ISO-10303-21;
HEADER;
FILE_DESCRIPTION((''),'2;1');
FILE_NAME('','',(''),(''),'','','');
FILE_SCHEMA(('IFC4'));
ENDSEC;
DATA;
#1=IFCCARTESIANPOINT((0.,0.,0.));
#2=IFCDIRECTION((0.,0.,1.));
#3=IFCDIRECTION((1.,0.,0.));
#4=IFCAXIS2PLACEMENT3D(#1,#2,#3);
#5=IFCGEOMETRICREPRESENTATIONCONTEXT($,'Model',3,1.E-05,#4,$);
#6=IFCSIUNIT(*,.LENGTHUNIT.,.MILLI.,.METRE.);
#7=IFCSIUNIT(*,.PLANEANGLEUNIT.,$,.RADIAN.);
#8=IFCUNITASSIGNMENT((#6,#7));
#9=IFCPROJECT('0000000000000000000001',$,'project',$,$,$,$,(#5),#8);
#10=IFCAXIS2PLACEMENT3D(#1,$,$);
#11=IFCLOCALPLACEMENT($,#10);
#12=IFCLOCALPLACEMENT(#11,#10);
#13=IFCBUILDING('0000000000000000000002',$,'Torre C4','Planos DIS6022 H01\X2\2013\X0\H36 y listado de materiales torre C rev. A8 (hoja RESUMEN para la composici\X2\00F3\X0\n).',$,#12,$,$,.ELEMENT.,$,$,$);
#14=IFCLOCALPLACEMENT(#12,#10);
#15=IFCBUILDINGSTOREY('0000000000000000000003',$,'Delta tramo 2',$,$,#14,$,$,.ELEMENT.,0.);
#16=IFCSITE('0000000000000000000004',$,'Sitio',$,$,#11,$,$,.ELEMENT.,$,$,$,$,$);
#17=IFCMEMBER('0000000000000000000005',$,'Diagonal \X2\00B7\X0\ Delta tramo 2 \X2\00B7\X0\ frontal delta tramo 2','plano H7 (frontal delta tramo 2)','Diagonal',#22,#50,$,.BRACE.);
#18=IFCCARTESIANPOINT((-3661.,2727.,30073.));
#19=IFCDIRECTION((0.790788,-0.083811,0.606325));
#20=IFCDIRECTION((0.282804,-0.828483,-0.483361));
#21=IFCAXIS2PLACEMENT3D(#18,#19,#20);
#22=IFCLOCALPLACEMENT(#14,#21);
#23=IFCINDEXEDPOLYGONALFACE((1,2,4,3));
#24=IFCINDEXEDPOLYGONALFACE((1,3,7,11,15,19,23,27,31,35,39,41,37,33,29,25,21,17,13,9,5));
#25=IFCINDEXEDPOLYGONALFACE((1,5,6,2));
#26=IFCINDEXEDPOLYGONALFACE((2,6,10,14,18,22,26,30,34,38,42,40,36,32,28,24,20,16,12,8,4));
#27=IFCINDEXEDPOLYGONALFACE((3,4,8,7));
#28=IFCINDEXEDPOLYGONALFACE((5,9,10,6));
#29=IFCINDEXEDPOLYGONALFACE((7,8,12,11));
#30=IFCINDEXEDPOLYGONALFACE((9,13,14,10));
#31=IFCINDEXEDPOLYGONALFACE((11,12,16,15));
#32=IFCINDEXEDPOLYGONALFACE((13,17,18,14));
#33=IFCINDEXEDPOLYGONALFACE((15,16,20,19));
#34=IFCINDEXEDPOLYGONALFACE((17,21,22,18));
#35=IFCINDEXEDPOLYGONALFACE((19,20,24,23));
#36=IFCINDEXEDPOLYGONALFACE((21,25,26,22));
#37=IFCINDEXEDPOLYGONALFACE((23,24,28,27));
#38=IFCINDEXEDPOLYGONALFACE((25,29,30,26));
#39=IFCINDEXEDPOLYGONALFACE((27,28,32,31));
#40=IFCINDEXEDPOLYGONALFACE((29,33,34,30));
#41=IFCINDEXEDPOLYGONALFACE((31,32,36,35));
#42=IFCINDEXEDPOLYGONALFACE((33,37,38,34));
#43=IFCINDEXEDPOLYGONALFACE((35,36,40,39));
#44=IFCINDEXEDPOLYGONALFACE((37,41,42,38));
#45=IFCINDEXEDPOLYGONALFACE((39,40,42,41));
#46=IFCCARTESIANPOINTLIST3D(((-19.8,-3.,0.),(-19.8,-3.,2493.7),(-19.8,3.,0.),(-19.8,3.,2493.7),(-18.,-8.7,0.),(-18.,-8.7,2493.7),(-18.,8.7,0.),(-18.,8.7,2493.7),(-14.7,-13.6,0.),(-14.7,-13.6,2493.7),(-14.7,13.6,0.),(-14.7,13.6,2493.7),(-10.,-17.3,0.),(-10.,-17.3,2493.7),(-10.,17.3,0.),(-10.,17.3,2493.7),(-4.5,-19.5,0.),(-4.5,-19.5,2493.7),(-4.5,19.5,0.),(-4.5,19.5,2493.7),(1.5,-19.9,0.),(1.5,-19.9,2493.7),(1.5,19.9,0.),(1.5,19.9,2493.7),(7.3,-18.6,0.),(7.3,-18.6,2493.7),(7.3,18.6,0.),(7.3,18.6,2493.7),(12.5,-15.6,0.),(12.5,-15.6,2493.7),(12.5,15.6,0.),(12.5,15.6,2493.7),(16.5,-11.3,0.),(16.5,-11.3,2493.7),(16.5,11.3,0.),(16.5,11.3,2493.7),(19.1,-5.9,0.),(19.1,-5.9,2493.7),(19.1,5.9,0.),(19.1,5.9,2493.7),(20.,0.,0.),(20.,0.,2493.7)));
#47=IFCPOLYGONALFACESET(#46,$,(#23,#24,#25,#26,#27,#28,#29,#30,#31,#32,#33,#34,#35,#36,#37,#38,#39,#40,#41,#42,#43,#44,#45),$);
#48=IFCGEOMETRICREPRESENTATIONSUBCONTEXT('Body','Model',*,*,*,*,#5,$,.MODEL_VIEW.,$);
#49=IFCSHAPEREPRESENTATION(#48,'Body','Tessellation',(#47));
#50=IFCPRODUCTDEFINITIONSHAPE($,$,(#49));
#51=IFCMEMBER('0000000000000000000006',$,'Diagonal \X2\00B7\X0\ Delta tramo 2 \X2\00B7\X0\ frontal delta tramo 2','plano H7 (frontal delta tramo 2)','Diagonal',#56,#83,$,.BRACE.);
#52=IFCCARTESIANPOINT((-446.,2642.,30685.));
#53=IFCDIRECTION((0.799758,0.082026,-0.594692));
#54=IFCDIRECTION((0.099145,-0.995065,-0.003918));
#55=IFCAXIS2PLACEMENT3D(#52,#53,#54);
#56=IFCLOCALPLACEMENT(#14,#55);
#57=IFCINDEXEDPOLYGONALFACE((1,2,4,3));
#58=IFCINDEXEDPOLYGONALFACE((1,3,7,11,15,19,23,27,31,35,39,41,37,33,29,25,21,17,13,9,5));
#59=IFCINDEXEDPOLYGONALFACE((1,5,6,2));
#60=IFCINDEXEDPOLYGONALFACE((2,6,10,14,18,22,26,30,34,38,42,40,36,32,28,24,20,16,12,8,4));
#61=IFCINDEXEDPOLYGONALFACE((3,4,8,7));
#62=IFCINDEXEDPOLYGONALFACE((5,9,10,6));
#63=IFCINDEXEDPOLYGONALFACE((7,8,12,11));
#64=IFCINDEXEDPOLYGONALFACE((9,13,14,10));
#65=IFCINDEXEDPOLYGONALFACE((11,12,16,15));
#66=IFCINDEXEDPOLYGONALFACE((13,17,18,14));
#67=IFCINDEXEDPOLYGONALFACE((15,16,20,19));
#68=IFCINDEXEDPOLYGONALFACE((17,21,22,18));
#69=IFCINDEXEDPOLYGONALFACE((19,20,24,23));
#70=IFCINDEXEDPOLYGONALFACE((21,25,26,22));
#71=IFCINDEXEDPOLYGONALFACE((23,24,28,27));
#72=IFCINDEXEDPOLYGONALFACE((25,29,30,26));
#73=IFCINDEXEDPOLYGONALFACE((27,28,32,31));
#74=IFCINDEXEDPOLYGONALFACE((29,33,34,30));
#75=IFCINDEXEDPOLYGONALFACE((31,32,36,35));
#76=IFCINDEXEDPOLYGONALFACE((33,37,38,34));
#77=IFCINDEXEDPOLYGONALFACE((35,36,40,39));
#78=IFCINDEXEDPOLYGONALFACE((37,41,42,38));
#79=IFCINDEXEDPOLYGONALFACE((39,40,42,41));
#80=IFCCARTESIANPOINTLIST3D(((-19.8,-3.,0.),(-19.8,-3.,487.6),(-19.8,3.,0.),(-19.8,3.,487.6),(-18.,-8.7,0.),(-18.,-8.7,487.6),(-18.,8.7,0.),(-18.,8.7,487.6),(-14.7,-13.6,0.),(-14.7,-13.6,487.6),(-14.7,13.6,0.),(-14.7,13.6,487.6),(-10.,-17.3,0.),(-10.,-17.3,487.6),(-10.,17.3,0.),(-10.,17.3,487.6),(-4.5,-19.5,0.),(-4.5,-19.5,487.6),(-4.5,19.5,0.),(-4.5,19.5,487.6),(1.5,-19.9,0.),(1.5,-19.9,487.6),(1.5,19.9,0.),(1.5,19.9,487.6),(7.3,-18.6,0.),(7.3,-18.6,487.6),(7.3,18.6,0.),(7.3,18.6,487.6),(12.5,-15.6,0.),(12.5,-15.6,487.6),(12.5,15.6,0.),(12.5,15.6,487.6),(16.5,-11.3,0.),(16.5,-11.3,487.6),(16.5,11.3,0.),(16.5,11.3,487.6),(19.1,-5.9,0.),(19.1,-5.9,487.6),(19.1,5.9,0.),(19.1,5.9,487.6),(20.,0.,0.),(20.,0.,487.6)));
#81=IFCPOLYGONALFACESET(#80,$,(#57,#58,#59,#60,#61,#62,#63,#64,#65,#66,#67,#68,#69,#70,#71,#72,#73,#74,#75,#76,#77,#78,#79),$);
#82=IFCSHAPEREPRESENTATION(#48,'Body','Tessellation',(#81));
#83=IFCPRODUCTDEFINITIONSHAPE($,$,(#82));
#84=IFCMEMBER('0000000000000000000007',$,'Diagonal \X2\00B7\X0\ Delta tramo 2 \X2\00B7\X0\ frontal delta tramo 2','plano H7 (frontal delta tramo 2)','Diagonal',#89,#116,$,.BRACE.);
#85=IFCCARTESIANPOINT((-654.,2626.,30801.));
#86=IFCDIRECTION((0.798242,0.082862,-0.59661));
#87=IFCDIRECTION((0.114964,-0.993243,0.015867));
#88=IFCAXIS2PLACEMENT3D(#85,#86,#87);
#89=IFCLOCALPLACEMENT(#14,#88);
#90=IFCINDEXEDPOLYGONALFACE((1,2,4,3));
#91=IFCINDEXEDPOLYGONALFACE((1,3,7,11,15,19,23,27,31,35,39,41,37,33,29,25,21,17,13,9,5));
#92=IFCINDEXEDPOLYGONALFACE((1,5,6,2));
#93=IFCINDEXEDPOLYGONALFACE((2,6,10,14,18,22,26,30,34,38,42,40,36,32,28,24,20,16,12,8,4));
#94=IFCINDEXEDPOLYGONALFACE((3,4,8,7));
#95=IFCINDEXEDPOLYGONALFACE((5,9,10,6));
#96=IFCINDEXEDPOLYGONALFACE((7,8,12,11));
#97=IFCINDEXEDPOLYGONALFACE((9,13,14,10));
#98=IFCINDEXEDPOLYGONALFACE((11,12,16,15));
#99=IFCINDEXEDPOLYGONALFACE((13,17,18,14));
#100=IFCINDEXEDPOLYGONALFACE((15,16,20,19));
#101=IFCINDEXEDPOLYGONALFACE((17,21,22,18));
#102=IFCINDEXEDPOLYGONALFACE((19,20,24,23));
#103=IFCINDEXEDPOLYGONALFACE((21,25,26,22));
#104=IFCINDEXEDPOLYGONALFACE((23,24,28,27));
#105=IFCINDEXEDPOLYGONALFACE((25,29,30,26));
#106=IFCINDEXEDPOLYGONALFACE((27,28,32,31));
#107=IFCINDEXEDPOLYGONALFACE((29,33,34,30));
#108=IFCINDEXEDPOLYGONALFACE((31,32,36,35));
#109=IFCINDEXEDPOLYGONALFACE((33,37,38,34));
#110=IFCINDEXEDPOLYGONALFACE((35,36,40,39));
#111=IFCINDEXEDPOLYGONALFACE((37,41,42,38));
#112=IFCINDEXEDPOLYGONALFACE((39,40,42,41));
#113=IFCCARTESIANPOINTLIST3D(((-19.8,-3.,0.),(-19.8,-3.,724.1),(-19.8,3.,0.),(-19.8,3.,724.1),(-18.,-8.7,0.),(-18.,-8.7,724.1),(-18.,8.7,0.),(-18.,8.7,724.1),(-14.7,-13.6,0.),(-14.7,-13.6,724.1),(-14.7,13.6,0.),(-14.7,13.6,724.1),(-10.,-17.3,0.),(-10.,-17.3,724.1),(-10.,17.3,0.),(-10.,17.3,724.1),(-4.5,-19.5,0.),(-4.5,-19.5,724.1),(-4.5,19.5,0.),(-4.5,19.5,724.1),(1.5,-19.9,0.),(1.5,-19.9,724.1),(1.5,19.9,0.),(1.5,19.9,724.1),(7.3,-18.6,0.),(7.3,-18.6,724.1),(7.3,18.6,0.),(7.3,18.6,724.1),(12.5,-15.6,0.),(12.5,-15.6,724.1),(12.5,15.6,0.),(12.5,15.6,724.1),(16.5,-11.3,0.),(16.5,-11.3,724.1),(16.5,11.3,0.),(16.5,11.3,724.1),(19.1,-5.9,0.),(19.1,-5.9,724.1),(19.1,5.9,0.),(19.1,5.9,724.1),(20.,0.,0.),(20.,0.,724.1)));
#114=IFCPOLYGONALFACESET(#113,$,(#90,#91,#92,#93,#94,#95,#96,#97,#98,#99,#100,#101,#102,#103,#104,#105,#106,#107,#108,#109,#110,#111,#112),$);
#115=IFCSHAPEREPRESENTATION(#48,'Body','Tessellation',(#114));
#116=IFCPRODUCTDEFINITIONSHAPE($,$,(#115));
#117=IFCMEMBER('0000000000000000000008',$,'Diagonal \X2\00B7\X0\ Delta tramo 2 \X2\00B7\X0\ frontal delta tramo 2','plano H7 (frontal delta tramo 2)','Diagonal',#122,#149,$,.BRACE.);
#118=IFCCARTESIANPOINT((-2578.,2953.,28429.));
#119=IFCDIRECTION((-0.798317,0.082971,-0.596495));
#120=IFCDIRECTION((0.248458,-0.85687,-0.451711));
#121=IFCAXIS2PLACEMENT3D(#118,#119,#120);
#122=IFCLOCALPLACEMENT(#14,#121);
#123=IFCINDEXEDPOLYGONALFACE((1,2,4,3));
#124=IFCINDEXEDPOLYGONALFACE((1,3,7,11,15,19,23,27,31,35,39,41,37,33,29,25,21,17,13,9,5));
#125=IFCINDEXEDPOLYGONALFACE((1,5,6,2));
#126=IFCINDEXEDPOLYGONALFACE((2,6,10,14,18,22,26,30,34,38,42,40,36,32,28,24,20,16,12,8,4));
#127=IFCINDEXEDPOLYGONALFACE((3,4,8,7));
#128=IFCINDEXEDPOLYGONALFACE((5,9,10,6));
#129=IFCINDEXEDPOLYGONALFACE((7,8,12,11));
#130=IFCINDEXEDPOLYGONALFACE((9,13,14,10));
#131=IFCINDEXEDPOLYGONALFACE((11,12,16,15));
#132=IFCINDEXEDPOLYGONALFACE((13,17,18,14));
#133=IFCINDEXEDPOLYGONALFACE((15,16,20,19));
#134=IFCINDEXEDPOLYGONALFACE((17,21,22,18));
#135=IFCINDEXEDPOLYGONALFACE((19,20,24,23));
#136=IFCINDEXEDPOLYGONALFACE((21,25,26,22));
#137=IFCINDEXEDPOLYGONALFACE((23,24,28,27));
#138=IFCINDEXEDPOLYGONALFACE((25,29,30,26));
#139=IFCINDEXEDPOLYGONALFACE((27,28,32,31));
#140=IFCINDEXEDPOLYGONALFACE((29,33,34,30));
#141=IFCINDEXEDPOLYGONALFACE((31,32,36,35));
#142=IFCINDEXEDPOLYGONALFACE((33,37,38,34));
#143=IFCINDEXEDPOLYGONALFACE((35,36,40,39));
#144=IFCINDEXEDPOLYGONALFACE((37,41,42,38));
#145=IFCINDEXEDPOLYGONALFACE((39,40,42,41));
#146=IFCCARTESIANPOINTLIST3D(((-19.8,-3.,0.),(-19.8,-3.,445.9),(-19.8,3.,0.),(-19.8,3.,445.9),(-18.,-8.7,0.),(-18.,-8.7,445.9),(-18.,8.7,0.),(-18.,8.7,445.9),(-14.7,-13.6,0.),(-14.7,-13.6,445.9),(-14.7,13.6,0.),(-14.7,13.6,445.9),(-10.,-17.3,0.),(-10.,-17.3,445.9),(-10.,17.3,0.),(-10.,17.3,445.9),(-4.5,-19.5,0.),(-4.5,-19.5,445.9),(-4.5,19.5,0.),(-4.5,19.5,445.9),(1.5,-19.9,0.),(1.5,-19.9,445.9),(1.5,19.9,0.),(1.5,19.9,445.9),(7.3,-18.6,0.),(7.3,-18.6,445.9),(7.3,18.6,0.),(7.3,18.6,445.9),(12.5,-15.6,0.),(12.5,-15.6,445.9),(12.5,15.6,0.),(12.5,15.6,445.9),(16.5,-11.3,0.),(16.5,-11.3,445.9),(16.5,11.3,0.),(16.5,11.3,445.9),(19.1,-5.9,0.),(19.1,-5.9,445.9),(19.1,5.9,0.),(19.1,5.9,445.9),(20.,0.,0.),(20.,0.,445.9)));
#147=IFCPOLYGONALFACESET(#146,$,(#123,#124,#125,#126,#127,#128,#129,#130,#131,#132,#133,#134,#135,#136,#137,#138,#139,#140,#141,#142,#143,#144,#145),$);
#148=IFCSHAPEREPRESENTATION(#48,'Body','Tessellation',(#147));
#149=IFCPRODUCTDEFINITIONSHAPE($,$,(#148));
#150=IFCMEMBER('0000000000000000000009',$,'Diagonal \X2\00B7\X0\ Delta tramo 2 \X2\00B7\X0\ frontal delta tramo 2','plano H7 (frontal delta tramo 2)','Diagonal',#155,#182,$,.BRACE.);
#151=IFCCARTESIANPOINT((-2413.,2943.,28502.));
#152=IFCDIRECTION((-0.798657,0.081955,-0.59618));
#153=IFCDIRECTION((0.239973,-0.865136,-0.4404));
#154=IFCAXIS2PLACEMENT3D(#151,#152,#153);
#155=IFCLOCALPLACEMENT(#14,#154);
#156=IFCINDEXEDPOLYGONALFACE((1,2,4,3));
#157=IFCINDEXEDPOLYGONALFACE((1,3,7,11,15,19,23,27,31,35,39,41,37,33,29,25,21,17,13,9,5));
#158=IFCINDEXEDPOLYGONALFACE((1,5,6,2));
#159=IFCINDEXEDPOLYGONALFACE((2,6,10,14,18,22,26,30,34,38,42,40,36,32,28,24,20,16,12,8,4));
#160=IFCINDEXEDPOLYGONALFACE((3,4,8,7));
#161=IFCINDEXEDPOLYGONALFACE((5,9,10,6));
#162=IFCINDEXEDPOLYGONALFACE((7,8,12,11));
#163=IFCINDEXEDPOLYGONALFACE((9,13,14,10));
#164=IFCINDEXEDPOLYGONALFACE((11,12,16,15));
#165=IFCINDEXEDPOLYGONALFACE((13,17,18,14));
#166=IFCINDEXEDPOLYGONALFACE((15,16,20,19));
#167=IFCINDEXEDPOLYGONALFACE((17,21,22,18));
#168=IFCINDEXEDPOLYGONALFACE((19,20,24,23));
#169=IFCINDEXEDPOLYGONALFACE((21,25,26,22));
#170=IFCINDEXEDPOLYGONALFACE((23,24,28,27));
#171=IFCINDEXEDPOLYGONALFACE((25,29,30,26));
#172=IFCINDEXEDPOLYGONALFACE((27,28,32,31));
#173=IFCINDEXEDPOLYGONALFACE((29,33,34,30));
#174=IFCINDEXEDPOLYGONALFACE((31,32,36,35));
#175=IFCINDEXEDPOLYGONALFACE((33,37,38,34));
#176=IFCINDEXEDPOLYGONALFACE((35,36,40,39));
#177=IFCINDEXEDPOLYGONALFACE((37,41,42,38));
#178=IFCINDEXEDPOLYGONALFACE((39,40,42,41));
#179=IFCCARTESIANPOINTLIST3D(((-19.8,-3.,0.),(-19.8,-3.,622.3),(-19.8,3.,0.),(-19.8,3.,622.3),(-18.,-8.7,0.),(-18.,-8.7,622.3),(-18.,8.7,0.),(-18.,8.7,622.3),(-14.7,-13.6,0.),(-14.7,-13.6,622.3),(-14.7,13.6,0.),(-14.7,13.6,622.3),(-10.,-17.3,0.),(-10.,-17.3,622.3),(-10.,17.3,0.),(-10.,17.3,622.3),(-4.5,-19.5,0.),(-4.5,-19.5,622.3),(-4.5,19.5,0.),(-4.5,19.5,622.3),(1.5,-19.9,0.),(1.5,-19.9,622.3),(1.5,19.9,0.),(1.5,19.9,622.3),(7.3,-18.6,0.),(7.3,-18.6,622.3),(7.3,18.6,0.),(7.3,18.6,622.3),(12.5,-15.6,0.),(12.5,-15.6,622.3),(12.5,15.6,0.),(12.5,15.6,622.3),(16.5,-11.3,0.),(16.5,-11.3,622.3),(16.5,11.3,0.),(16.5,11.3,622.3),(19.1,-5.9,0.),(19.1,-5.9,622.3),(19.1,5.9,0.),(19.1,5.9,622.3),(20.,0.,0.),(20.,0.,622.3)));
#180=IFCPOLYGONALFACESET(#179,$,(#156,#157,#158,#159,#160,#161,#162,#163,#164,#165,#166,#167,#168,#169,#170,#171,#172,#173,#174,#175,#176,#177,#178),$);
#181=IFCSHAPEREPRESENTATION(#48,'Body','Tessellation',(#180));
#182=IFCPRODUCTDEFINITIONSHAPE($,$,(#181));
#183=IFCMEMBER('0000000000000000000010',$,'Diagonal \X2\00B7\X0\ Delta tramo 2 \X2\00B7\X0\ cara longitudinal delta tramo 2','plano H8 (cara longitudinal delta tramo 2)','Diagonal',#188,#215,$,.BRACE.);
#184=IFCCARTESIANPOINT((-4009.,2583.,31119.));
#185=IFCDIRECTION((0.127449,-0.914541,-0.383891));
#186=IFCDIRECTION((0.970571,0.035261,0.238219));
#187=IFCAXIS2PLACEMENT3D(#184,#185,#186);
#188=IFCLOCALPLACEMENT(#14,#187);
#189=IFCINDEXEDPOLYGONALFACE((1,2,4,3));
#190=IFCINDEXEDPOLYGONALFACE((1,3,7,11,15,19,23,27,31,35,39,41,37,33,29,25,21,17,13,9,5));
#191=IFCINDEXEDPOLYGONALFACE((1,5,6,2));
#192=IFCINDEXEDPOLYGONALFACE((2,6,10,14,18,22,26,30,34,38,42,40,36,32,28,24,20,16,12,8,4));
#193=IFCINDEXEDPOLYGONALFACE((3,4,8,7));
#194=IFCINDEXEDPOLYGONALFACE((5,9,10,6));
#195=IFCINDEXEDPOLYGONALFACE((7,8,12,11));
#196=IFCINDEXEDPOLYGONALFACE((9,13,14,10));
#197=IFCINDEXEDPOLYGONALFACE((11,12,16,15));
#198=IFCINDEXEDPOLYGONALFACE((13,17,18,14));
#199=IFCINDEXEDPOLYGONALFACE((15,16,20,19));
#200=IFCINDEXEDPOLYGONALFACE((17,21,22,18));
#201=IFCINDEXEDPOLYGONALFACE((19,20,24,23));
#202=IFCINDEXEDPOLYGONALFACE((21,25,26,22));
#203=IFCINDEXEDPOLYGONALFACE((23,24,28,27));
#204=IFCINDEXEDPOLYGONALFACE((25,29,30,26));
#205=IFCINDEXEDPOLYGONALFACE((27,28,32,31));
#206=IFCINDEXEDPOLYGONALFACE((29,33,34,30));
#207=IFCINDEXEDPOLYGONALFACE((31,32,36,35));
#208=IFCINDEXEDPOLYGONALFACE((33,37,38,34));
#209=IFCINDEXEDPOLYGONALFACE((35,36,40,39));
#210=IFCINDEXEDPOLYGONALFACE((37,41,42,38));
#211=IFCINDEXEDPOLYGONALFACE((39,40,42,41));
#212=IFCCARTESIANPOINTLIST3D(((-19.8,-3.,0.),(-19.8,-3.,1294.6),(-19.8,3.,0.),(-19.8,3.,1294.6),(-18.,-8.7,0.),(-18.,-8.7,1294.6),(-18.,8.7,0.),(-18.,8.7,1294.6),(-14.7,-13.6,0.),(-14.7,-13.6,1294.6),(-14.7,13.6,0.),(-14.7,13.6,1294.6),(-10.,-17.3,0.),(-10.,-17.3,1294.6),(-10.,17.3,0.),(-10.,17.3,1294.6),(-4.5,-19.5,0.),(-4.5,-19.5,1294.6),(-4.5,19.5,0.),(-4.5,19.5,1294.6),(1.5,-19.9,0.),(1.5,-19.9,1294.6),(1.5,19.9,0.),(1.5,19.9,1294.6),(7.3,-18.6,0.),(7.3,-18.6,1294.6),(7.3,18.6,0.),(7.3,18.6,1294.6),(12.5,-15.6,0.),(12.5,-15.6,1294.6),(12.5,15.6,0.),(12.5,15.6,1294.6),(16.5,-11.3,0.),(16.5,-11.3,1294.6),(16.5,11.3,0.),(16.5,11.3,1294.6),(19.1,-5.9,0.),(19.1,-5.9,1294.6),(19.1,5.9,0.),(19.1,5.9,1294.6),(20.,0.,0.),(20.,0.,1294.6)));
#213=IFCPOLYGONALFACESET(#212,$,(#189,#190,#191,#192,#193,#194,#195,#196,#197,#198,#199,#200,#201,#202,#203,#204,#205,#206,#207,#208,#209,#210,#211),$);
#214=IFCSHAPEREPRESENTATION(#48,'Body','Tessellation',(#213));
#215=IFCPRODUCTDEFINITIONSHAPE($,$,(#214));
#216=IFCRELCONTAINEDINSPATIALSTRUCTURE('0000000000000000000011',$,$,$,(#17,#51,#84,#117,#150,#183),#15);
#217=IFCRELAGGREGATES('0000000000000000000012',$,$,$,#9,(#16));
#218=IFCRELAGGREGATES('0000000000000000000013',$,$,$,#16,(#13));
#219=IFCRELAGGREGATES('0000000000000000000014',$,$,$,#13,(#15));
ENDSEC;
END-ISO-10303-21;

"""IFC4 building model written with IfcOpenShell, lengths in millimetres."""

from ifc_helpers import new_model, si_unit, frame, origin, origin_with_axes, place, context, subcontext, project, spatial, circle, extrude, element, save


model = new_model("IFC4")

# Units and contexts
model_context = context("Model", 3, precision=1e-05, world=origin_with_axes())
body_context = subcontext(model_context, "Body", "Model", "MODEL_VIEW")
ifc_project = project(units=[si_unit("LENGTHUNIT", "METRE", prefix="MILLI"), si_unit("PLANEANGLEUNIT", "RADIAN")], contexts=[model_context])

# Site, building, storey
site_placement = place(None, origin())
site = spatial("IfcSite", under=ifc_project, at=site_placement, Name="Sitio", CompositionType="ELEMENT")
building_placement = place(site_placement, origin())
building = spatial("IfcBuilding", under=site, at=building_placement, Name="Torre C4", Description="Planos DIS6022 H01–H36 y listado de materiales torre C rev. A8 (hoja RESUMEN para la composición).", CompositionType="ELEMENT")
storey_placement = place(building_placement, origin())
storey = spatial("IfcBuildingStorey", under=building, at=storey_placement, Name="Delta tramo 2", CompositionType="ELEMENT", Elevation=0.0)

# Members
member_1_placement = place(storey_placement, frame((-3661.0, 2727.0, 30073.0), z_axis=(0.790788, -0.083811, 0.606325), x_axis=(0.282804, -0.828483, -0.483361)))
element("IfcMember", 1, at=member_1_placement, inside=storey, Name="Diagonal · Delta tramo 2 · frontal delta tramo 2", Description="plano H7 (frontal delta tramo 2)", ObjectType="Diagonal", PredefinedType="BRACE", context=body_context, shape_type="SweptSolid", body=[
    extrude(circle(Radius=20.0), None, (0.0, 0.0, 1.0), 2493.7),
])
member_2_placement = place(storey_placement, frame((-446.0, 2642.0, 30685.0), z_axis=(0.799758, 0.082026, -0.594692), x_axis=(0.099145, -0.995065, -0.003918)))
element("IfcMember", 2, at=member_2_placement, inside=storey, Name="Diagonal · Delta tramo 2 · frontal delta tramo 2", Description="plano H7 (frontal delta tramo 2)", ObjectType="Diagonal", PredefinedType="BRACE", context=body_context, shape_type="SweptSolid", body=[
    extrude(circle(Radius=20.0), None, (0.0, 0.0, 1.0), 487.6),
])
member_3_placement = place(storey_placement, frame((-654.0, 2626.0, 30801.0), z_axis=(0.798242, 0.082862, -0.59661), x_axis=(0.114964, -0.993243, 0.015867)))
element("IfcMember", 3, at=member_3_placement, inside=storey, Name="Diagonal · Delta tramo 2 · frontal delta tramo 2", Description="plano H7 (frontal delta tramo 2)", ObjectType="Diagonal", PredefinedType="BRACE", context=body_context, shape_type="SweptSolid", body=[
    extrude(circle(Radius=20.0), None, (0.0, 0.0, 1.0), 724.1),
])
member_4_placement = place(storey_placement, frame((-2578.0, 2953.0, 28429.0), z_axis=(-0.798317, 0.082971, -0.596495), x_axis=(0.248458, -0.85687, -0.451711)))
element("IfcMember", 4, at=member_4_placement, inside=storey, Name="Diagonal · Delta tramo 2 · frontal delta tramo 2", Description="plano H7 (frontal delta tramo 2)", ObjectType="Diagonal", PredefinedType="BRACE", context=body_context, shape_type="SweptSolid", body=[
    extrude(circle(Radius=20.0), None, (0.0, 0.0, 1.0), 445.9),
])
member_5_placement = place(storey_placement, frame((-2413.0, 2943.0, 28502.0), z_axis=(-0.798657, 0.081955, -0.59618), x_axis=(0.239973, -0.865136, -0.4404)))
element("IfcMember", 5, at=member_5_placement, inside=storey, Name="Diagonal · Delta tramo 2 · frontal delta tramo 2", Description="plano H7 (frontal delta tramo 2)", ObjectType="Diagonal", PredefinedType="BRACE", context=body_context, shape_type="SweptSolid", body=[
    extrude(circle(Radius=20.0), None, (0.0, 0.0, 1.0), 622.3),
])
member_6_placement = place(storey_placement, frame((-4009.0, 2583.0, 31119.0), z_axis=(0.127449, -0.914541, -0.383891), x_axis=(0.970571, 0.035261, 0.238219)))
element("IfcMember", 6, at=member_6_placement, inside=storey, Name="Diagonal · Delta tramo 2 · cara longitudinal delta tramo 2", Description="plano H8 (cara longitudinal delta tramo 2)", ObjectType="Diagonal", PredefinedType="BRACE", context=body_context, shape_type="SweptSolid", body=[
    extrude(circle(Radius=20.0), None, (0.0, 0.0, 1.0), 1294.6),
])

save(model, "model.ifc")
